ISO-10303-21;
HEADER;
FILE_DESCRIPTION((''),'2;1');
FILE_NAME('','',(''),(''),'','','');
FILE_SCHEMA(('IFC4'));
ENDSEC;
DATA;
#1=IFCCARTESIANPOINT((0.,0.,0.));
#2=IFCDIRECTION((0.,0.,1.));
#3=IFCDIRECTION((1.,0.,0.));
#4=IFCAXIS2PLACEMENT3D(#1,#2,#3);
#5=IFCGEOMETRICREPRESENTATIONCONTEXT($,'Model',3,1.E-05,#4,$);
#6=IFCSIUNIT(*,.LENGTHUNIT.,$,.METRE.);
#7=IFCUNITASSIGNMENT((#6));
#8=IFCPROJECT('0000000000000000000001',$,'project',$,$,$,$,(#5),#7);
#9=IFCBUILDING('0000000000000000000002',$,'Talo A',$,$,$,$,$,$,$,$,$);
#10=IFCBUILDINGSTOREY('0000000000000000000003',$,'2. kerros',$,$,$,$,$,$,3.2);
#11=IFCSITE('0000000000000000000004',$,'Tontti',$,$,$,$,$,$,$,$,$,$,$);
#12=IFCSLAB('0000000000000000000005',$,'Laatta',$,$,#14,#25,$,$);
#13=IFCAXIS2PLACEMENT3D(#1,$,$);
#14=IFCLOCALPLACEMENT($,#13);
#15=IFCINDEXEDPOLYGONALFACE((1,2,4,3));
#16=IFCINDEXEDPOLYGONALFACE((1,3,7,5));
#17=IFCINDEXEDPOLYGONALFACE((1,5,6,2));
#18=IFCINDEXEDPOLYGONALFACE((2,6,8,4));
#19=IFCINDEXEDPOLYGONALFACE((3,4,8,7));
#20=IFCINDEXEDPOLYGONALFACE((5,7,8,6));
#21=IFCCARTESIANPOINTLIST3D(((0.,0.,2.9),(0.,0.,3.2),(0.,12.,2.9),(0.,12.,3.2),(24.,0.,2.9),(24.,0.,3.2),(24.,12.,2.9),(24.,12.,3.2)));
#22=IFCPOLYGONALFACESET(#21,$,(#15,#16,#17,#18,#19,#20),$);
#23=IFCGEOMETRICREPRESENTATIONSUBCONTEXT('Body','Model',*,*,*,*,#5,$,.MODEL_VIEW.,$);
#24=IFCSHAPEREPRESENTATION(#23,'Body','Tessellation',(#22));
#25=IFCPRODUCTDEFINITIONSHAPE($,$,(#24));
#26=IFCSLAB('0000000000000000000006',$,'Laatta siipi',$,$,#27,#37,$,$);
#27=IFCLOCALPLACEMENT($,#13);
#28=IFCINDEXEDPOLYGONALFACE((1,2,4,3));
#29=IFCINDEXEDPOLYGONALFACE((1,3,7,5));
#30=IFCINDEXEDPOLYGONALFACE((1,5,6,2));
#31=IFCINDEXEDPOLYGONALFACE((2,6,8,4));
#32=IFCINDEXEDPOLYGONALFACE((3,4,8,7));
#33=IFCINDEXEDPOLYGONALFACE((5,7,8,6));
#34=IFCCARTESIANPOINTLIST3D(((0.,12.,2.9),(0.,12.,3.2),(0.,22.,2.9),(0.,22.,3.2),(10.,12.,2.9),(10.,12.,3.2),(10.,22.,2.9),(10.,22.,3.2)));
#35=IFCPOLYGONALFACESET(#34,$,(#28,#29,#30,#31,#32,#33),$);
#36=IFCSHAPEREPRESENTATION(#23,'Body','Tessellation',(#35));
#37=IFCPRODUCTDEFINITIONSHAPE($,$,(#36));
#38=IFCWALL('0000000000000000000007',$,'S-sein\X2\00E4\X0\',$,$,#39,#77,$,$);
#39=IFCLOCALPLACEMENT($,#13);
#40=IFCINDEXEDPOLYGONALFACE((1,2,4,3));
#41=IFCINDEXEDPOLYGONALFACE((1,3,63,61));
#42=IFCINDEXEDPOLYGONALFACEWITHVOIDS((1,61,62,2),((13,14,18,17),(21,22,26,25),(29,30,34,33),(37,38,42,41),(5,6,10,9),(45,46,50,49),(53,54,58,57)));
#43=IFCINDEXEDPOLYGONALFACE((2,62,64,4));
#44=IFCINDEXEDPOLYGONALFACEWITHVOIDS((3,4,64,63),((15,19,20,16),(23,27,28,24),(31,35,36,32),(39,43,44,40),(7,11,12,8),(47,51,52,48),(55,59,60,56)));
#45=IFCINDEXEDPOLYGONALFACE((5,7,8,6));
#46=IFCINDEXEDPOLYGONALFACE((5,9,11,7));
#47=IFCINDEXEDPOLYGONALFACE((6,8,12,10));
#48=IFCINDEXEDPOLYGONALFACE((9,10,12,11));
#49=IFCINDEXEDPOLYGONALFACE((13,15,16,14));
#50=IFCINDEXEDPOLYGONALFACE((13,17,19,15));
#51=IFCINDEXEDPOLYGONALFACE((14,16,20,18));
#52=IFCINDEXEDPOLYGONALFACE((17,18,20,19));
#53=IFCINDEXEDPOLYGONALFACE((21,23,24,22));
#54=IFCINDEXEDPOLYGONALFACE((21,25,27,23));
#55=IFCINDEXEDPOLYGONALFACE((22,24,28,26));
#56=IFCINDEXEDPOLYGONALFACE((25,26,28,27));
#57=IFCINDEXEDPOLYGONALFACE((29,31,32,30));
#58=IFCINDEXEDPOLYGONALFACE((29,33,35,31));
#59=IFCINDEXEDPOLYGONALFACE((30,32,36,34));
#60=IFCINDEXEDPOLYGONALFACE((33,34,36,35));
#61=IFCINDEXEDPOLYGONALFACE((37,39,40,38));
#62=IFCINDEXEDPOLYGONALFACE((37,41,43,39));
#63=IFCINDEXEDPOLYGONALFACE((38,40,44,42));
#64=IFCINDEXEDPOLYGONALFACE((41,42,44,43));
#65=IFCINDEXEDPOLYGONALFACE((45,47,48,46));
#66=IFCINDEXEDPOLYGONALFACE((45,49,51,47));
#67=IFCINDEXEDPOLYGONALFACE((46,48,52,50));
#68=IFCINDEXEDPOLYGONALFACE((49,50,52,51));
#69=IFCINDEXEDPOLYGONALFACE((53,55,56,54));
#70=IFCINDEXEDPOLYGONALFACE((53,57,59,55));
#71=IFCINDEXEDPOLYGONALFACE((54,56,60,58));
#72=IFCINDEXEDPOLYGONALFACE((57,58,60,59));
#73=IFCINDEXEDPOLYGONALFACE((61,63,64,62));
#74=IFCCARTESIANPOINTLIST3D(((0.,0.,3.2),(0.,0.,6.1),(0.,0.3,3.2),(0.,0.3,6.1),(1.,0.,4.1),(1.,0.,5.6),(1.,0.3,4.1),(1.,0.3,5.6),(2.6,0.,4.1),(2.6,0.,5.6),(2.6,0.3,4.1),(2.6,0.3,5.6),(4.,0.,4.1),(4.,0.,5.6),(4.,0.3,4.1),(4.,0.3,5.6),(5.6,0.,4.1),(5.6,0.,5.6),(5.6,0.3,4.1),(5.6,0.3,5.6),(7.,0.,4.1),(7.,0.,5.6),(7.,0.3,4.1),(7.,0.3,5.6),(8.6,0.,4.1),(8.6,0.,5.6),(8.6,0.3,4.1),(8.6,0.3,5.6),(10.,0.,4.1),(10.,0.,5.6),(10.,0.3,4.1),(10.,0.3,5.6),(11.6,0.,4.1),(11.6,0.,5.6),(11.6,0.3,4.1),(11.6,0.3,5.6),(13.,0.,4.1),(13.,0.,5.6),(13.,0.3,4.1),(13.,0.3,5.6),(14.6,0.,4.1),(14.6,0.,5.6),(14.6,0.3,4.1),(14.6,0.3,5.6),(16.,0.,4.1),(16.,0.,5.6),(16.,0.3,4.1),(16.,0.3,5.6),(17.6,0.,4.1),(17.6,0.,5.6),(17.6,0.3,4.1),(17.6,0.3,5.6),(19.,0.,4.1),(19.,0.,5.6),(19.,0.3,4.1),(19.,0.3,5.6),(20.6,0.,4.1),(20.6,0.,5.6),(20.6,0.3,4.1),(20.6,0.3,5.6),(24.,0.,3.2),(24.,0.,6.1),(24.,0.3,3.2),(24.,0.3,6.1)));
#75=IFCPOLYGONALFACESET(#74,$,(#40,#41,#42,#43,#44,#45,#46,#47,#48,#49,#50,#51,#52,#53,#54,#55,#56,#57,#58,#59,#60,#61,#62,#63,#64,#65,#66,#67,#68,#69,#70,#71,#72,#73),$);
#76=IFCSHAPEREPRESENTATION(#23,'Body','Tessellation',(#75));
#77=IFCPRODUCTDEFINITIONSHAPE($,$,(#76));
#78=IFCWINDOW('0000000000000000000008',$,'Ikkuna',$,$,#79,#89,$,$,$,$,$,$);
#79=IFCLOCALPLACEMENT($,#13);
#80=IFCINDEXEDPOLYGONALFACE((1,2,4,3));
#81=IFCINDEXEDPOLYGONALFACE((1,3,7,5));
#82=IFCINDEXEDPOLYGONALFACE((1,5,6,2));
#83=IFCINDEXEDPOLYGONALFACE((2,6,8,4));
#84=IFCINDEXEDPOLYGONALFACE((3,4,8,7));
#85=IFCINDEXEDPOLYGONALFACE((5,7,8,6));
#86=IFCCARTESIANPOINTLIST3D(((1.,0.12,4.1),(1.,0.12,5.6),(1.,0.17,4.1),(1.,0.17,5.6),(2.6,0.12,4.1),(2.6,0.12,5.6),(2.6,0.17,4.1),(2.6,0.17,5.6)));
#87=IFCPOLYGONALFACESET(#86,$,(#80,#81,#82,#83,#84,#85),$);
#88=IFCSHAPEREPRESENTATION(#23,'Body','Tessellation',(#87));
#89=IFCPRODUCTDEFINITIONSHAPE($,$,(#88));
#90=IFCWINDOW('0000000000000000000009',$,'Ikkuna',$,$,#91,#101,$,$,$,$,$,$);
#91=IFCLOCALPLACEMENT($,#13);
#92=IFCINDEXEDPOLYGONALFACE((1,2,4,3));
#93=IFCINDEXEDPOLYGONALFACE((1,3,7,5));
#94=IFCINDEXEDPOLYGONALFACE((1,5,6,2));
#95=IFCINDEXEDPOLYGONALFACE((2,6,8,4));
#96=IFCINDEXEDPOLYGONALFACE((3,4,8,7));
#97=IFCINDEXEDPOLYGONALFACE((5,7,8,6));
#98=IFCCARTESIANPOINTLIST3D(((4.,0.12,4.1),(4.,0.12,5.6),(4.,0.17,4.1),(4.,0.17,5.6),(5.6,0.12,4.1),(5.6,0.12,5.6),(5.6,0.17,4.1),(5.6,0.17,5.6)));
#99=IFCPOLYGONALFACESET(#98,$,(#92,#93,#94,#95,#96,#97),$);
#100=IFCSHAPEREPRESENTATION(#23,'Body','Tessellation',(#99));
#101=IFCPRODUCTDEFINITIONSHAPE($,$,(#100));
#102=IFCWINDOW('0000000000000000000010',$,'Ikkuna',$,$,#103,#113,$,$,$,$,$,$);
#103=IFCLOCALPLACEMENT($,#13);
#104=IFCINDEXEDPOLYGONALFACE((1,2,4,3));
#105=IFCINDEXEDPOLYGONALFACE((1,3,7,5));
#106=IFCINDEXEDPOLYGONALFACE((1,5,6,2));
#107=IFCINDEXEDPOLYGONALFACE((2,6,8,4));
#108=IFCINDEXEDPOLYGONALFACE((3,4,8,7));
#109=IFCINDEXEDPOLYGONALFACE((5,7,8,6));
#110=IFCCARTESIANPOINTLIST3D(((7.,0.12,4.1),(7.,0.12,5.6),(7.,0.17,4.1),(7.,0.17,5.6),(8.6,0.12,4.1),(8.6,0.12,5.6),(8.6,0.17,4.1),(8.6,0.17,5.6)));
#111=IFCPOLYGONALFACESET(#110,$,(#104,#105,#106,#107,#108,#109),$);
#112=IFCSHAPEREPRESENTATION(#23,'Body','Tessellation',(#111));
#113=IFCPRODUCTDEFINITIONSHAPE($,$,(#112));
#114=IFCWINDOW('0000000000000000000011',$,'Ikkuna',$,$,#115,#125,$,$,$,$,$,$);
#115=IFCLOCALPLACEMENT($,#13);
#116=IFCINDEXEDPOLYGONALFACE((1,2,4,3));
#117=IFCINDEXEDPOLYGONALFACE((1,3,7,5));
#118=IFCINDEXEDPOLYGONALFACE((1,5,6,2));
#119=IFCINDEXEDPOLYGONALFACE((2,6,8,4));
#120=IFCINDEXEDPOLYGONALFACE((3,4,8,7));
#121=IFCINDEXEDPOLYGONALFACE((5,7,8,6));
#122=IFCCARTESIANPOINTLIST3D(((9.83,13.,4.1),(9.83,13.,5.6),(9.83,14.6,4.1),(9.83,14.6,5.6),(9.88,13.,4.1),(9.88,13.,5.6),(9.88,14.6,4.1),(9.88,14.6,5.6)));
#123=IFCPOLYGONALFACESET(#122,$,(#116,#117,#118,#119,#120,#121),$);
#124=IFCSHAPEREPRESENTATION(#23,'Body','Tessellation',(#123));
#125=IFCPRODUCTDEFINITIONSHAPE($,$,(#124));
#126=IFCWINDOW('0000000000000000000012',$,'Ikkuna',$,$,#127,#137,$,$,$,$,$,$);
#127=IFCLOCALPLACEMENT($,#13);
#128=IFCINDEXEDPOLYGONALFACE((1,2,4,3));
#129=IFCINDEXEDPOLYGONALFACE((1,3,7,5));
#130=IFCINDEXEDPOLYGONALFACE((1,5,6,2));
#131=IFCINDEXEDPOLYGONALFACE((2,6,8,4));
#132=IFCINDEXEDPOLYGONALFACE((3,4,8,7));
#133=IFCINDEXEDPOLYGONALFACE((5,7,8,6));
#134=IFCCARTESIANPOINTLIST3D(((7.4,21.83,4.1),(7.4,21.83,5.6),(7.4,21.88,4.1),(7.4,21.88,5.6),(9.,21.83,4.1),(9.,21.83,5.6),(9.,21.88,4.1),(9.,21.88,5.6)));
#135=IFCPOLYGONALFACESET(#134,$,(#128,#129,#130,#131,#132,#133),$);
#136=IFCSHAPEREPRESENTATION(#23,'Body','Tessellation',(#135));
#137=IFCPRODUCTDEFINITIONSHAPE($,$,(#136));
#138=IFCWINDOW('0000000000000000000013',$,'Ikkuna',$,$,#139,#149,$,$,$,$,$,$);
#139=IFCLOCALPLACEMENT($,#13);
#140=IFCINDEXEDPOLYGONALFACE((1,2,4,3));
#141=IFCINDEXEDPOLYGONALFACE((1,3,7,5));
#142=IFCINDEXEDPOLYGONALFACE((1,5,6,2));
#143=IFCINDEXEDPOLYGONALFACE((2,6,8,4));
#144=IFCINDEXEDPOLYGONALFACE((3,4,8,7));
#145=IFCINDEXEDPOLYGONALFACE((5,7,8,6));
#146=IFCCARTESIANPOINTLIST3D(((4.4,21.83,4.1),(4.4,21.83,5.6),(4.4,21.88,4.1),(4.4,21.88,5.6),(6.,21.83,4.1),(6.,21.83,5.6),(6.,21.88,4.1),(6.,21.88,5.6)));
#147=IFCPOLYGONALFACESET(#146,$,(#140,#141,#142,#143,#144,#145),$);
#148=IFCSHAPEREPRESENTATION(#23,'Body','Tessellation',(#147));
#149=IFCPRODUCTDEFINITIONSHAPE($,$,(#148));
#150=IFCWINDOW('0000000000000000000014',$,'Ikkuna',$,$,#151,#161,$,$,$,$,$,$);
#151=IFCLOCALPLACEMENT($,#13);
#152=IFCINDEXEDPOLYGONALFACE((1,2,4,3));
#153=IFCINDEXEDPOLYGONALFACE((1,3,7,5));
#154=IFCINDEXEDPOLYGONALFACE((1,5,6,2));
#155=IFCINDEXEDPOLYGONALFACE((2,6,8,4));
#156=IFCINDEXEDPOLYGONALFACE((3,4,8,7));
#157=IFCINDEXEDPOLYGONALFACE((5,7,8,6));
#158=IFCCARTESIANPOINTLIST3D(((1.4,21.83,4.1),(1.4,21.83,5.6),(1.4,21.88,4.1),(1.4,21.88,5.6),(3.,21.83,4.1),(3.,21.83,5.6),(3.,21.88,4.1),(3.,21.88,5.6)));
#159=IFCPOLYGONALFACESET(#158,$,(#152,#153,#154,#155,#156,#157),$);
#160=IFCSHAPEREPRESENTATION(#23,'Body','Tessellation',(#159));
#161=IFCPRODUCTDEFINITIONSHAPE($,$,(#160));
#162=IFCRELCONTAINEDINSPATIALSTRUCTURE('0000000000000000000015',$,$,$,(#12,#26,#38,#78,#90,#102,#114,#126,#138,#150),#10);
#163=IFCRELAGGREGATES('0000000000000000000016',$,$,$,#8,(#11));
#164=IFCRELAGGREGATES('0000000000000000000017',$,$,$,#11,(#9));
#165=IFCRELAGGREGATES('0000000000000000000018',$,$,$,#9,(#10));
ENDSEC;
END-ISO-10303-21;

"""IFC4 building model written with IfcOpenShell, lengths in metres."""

from ifc_helpers import new_model, si_unit, frame, origin_with_axes, place, context, subcontext, project, spatial, indexed_curve, outline, extrude, element, save


model = new_model("IFC4")

# Units and contexts
model_context = context("Model", 3, precision=1e-05, world=origin_with_axes())
body_context = subcontext(model_context, "Body", "Model", "MODEL_VIEW")
ifc_project = project(units=[si_unit("LENGTHUNIT", "METRE")], contexts=[model_context])

# Site, building, storey
site = spatial("IfcSite", under=ifc_project, Name="Tontti")
building = spatial("IfcBuilding", under=site, Name="Talo A")
storey = spatial("IfcBuildingStorey", under=building, Name="2. kerros", Elevation=3.2)

# Slabs
slab_1_placement = place(None, frame((0.0, 0.0, 2.9), z_axis=(0.0, 0.0, 1.0), x_axis=(1.0, 0.0, 0.0)))
element("IfcSlab", 1, at=slab_1_placement, inside=storey, Name="Laatta", context=body_context, shape_type="SweptSolid", body=[
    extrude(outline(indexed_curve([(0.0, 0.0), (0.0, 12.0), (24.0, 12.0), (24.0, 0.0), (0.0, 0.0)], self_intersect=False)), origin_with_axes(), (0.0, 0.0, 1.0), 0.3),
])
slab_2_placement = place(None, frame((0.0, 12.0, 2.9), z_axis=(0.0, 0.0, 1.0), x_axis=(1.0, 0.0, 0.0)))
element("IfcSlab", 2, at=slab_2_placement, inside=storey, Name="Laatta siipi", context=body_context, shape_type="SweptSolid", body=[
    extrude(outline(indexed_curve([(0.0, 0.0), (0.0, 10.0), (10.0, 10.0), (10.0, 0.0), (0.0, 0.0)], self_intersect=False)), origin_with_axes(), (0.0, 0.0, 1.0), 0.3),
])

# Wall, openings
wall_1_placement = place(None, frame((0.0, 0.0, 3.2), z_axis=(0.0, 0.0, 1.0), x_axis=(1.0, 0.0, 0.0)))
wall_1 = element("IfcWall", 3, at=wall_1_placement, inside=storey, Name="S-seinä", context=body_context, shape_type="SweptSolid", body=[
    extrude(outline(indexed_curve([(0.0, 0.0), (0.0, 0.3), (24.0, 0.3), (24.0, 0.0), (0.0, 0.0)], self_intersect=False)), origin_with_axes(), (0.0, 0.0, 1.0), 2.9),
])
opening_1_placement = place(wall_1_placement, frame((1.0, -0.1, 0.9), z_axis=(0.0, 0.0, 1.0), x_axis=(1.0, 0.0, 0.0)))
element("IfcOpeningElement", 4, at=opening_1_placement, cuts=wall_1, context=body_context, shape_type="SweptSolid", body=[
    extrude(outline(indexed_curve([(0.0, 0.0), (0.0, 0.5), (1.6, 0.5), (1.6, 0.0), (0.0, 0.0)], self_intersect=False)), origin_with_axes(), (0.0, 0.0, 1.0), 1.5),
])
opening_2_placement = place(wall_1_placement, frame((4.0, -0.1, 0.9), z_axis=(0.0, 0.0, 1.0), x_axis=(1.0, 0.0, 0.0)))
element("IfcOpeningElement", 5, at=opening_2_placement, cuts=wall_1, context=body_context, shape_type="SweptSolid", body=[
    extrude(outline(indexed_curve([(0.0, 0.0), (0.0, 0.5), (1.6, 0.5), (1.6, 0.0), (0.0, 0.0)], self_intersect=False)), origin_with_axes(), (0.0, 0.0, 1.0), 1.5),
])
opening_3_placement = place(wall_1_placement, frame((7.0, -0.1, 0.9), z_axis=(0.0, 0.0, 1.0), x_axis=(1.0, 0.0, 0.0)))
element("IfcOpeningElement", 6, at=opening_3_placement, cuts=wall_1, context=body_context, shape_type="SweptSolid", body=[
    extrude(outline(indexed_curve([(0.0, 0.0), (0.0, 0.5), (1.6, 0.5), (1.6, 0.0), (0.0, 0.0)], self_intersect=False)), origin_with_axes(), (0.0, 0.0, 1.0), 1.5),
])
opening_4_placement = place(wall_1_placement, frame((10.0, -0.1, 0.9), z_axis=(0.0, 0.0, 1.0), x_axis=(1.0, 0.0, 0.0)))
element("IfcOpeningElement", 7, at=opening_4_placement, cuts=wall_1, context=body_context, shape_type="SweptSolid", body=[
    extrude(outline(indexed_curve([(0.0, 0.0), (0.0, 0.5), (1.6, 0.5), (1.6, 0.0), (0.0, 0.0)], self_intersect=False)), origin_with_axes(), (0.0, 0.0, 1.0), 1.5),
])
opening_5_placement = place(wall_1_placement, frame((13.0, -0.1, 0.9), z_axis=(0.0, 0.0, 1.0), x_axis=(1.0, 0.0, 0.0)))
element("IfcOpeningElement", 8, at=opening_5_placement, cuts=wall_1, context=body_context, shape_type="SweptSolid", body=[
    extrude(outline(indexed_curve([(0.0, 0.0), (0.0, 0.5), (1.6, 0.5), (1.6, 0.0), (0.0, 0.0)], self_intersect=False)), origin_with_axes(), (0.0, 0.0, 1.0), 1.5),
])
opening_6_placement = place(wall_1_placement, frame((16.0, -0.1, 0.9), z_axis=(0.0, 0.0, 1.0), x_axis=(1.0, 0.0, 0.0)))
element("IfcOpeningElement", 9, at=opening_6_placement, cuts=wall_1, context=body_context, shape_type="SweptSolid", body=[
    extrude(outline(indexed_curve([(0.0, 0.0), (0.0, 0.5), (1.6, 0.5), (1.6, 0.0), (0.0, 0.0)], self_intersect=False)), origin_with_axes(), (0.0, 0.0, 1.0), 1.5),
])
opening_7_placement = place(wall_1_placement, frame((19.0, -0.1, 0.9), z_axis=(0.0, 0.0, 1.0), x_axis=(1.0, 0.0, 0.0)))
element("IfcOpeningElement", 10, at=opening_7_placement, cuts=wall_1, context=body_context, shape_type="SweptSolid", body=[
    extrude(outline(indexed_curve([(0.0, 0.0), (0.0, 0.5), (1.6, 0.5), (1.6, 0.0), (0.0, 0.0)], self_intersect=False)), origin_with_axes(), (0.0, 0.0, 1.0), 1.5),
])

# Windows
for number, where, z_axis, x_axis, name in (
    (11, (1.0, 0.12, 4.1), (0.0, 0.0, 1.0), (1.0, 0.0, 0.0), "Ikkuna"),
    (12, (4.0, 0.12, 4.1), (0.0, 0.0, 1.0), (1.0, 0.0, 0.0), "Ikkuna"),
    (13, (7.0, 0.12, 4.1), (0.0, 0.0, 1.0), (1.0, 0.0, 0.0), "Ikkuna"),
    (14, (9.88, 13.0, 4.1), (0.0, 0.0, 1.0), (0.0, 1.0, 0.0), "Ikkuna"),
    (15, (9.0, 21.88, 4.1), (0.0, 0.0, 1.0), (-1.0, 0.0, 0.0), "Ikkuna"),
    (16, (6.0, 21.88, 4.1), (0.0, 0.0, 1.0), (-1.0, 0.0, 0.0), "Ikkuna"),
    (17, (3.0, 21.88, 4.1), (0.0, 0.0, 1.0), (-1.0, 0.0, 0.0), "Ikkuna"),
):
    element("IfcWindow", number, at=place(None, frame(where, z_axis=z_axis, x_axis=x_axis)), inside=storey, Name=name, context=body_context, shape_type="SweptSolid", body=[
        extrude(outline(indexed_curve([(0.0, 0.0), (0.0, 0.05), (1.6, 0.05), (1.6, 0.0), (0.0, 0.0)], self_intersect=False)), origin_with_axes(), (0.0, 0.0, 1.0), 1.5),
    ])

save(model, "model.ifc")
